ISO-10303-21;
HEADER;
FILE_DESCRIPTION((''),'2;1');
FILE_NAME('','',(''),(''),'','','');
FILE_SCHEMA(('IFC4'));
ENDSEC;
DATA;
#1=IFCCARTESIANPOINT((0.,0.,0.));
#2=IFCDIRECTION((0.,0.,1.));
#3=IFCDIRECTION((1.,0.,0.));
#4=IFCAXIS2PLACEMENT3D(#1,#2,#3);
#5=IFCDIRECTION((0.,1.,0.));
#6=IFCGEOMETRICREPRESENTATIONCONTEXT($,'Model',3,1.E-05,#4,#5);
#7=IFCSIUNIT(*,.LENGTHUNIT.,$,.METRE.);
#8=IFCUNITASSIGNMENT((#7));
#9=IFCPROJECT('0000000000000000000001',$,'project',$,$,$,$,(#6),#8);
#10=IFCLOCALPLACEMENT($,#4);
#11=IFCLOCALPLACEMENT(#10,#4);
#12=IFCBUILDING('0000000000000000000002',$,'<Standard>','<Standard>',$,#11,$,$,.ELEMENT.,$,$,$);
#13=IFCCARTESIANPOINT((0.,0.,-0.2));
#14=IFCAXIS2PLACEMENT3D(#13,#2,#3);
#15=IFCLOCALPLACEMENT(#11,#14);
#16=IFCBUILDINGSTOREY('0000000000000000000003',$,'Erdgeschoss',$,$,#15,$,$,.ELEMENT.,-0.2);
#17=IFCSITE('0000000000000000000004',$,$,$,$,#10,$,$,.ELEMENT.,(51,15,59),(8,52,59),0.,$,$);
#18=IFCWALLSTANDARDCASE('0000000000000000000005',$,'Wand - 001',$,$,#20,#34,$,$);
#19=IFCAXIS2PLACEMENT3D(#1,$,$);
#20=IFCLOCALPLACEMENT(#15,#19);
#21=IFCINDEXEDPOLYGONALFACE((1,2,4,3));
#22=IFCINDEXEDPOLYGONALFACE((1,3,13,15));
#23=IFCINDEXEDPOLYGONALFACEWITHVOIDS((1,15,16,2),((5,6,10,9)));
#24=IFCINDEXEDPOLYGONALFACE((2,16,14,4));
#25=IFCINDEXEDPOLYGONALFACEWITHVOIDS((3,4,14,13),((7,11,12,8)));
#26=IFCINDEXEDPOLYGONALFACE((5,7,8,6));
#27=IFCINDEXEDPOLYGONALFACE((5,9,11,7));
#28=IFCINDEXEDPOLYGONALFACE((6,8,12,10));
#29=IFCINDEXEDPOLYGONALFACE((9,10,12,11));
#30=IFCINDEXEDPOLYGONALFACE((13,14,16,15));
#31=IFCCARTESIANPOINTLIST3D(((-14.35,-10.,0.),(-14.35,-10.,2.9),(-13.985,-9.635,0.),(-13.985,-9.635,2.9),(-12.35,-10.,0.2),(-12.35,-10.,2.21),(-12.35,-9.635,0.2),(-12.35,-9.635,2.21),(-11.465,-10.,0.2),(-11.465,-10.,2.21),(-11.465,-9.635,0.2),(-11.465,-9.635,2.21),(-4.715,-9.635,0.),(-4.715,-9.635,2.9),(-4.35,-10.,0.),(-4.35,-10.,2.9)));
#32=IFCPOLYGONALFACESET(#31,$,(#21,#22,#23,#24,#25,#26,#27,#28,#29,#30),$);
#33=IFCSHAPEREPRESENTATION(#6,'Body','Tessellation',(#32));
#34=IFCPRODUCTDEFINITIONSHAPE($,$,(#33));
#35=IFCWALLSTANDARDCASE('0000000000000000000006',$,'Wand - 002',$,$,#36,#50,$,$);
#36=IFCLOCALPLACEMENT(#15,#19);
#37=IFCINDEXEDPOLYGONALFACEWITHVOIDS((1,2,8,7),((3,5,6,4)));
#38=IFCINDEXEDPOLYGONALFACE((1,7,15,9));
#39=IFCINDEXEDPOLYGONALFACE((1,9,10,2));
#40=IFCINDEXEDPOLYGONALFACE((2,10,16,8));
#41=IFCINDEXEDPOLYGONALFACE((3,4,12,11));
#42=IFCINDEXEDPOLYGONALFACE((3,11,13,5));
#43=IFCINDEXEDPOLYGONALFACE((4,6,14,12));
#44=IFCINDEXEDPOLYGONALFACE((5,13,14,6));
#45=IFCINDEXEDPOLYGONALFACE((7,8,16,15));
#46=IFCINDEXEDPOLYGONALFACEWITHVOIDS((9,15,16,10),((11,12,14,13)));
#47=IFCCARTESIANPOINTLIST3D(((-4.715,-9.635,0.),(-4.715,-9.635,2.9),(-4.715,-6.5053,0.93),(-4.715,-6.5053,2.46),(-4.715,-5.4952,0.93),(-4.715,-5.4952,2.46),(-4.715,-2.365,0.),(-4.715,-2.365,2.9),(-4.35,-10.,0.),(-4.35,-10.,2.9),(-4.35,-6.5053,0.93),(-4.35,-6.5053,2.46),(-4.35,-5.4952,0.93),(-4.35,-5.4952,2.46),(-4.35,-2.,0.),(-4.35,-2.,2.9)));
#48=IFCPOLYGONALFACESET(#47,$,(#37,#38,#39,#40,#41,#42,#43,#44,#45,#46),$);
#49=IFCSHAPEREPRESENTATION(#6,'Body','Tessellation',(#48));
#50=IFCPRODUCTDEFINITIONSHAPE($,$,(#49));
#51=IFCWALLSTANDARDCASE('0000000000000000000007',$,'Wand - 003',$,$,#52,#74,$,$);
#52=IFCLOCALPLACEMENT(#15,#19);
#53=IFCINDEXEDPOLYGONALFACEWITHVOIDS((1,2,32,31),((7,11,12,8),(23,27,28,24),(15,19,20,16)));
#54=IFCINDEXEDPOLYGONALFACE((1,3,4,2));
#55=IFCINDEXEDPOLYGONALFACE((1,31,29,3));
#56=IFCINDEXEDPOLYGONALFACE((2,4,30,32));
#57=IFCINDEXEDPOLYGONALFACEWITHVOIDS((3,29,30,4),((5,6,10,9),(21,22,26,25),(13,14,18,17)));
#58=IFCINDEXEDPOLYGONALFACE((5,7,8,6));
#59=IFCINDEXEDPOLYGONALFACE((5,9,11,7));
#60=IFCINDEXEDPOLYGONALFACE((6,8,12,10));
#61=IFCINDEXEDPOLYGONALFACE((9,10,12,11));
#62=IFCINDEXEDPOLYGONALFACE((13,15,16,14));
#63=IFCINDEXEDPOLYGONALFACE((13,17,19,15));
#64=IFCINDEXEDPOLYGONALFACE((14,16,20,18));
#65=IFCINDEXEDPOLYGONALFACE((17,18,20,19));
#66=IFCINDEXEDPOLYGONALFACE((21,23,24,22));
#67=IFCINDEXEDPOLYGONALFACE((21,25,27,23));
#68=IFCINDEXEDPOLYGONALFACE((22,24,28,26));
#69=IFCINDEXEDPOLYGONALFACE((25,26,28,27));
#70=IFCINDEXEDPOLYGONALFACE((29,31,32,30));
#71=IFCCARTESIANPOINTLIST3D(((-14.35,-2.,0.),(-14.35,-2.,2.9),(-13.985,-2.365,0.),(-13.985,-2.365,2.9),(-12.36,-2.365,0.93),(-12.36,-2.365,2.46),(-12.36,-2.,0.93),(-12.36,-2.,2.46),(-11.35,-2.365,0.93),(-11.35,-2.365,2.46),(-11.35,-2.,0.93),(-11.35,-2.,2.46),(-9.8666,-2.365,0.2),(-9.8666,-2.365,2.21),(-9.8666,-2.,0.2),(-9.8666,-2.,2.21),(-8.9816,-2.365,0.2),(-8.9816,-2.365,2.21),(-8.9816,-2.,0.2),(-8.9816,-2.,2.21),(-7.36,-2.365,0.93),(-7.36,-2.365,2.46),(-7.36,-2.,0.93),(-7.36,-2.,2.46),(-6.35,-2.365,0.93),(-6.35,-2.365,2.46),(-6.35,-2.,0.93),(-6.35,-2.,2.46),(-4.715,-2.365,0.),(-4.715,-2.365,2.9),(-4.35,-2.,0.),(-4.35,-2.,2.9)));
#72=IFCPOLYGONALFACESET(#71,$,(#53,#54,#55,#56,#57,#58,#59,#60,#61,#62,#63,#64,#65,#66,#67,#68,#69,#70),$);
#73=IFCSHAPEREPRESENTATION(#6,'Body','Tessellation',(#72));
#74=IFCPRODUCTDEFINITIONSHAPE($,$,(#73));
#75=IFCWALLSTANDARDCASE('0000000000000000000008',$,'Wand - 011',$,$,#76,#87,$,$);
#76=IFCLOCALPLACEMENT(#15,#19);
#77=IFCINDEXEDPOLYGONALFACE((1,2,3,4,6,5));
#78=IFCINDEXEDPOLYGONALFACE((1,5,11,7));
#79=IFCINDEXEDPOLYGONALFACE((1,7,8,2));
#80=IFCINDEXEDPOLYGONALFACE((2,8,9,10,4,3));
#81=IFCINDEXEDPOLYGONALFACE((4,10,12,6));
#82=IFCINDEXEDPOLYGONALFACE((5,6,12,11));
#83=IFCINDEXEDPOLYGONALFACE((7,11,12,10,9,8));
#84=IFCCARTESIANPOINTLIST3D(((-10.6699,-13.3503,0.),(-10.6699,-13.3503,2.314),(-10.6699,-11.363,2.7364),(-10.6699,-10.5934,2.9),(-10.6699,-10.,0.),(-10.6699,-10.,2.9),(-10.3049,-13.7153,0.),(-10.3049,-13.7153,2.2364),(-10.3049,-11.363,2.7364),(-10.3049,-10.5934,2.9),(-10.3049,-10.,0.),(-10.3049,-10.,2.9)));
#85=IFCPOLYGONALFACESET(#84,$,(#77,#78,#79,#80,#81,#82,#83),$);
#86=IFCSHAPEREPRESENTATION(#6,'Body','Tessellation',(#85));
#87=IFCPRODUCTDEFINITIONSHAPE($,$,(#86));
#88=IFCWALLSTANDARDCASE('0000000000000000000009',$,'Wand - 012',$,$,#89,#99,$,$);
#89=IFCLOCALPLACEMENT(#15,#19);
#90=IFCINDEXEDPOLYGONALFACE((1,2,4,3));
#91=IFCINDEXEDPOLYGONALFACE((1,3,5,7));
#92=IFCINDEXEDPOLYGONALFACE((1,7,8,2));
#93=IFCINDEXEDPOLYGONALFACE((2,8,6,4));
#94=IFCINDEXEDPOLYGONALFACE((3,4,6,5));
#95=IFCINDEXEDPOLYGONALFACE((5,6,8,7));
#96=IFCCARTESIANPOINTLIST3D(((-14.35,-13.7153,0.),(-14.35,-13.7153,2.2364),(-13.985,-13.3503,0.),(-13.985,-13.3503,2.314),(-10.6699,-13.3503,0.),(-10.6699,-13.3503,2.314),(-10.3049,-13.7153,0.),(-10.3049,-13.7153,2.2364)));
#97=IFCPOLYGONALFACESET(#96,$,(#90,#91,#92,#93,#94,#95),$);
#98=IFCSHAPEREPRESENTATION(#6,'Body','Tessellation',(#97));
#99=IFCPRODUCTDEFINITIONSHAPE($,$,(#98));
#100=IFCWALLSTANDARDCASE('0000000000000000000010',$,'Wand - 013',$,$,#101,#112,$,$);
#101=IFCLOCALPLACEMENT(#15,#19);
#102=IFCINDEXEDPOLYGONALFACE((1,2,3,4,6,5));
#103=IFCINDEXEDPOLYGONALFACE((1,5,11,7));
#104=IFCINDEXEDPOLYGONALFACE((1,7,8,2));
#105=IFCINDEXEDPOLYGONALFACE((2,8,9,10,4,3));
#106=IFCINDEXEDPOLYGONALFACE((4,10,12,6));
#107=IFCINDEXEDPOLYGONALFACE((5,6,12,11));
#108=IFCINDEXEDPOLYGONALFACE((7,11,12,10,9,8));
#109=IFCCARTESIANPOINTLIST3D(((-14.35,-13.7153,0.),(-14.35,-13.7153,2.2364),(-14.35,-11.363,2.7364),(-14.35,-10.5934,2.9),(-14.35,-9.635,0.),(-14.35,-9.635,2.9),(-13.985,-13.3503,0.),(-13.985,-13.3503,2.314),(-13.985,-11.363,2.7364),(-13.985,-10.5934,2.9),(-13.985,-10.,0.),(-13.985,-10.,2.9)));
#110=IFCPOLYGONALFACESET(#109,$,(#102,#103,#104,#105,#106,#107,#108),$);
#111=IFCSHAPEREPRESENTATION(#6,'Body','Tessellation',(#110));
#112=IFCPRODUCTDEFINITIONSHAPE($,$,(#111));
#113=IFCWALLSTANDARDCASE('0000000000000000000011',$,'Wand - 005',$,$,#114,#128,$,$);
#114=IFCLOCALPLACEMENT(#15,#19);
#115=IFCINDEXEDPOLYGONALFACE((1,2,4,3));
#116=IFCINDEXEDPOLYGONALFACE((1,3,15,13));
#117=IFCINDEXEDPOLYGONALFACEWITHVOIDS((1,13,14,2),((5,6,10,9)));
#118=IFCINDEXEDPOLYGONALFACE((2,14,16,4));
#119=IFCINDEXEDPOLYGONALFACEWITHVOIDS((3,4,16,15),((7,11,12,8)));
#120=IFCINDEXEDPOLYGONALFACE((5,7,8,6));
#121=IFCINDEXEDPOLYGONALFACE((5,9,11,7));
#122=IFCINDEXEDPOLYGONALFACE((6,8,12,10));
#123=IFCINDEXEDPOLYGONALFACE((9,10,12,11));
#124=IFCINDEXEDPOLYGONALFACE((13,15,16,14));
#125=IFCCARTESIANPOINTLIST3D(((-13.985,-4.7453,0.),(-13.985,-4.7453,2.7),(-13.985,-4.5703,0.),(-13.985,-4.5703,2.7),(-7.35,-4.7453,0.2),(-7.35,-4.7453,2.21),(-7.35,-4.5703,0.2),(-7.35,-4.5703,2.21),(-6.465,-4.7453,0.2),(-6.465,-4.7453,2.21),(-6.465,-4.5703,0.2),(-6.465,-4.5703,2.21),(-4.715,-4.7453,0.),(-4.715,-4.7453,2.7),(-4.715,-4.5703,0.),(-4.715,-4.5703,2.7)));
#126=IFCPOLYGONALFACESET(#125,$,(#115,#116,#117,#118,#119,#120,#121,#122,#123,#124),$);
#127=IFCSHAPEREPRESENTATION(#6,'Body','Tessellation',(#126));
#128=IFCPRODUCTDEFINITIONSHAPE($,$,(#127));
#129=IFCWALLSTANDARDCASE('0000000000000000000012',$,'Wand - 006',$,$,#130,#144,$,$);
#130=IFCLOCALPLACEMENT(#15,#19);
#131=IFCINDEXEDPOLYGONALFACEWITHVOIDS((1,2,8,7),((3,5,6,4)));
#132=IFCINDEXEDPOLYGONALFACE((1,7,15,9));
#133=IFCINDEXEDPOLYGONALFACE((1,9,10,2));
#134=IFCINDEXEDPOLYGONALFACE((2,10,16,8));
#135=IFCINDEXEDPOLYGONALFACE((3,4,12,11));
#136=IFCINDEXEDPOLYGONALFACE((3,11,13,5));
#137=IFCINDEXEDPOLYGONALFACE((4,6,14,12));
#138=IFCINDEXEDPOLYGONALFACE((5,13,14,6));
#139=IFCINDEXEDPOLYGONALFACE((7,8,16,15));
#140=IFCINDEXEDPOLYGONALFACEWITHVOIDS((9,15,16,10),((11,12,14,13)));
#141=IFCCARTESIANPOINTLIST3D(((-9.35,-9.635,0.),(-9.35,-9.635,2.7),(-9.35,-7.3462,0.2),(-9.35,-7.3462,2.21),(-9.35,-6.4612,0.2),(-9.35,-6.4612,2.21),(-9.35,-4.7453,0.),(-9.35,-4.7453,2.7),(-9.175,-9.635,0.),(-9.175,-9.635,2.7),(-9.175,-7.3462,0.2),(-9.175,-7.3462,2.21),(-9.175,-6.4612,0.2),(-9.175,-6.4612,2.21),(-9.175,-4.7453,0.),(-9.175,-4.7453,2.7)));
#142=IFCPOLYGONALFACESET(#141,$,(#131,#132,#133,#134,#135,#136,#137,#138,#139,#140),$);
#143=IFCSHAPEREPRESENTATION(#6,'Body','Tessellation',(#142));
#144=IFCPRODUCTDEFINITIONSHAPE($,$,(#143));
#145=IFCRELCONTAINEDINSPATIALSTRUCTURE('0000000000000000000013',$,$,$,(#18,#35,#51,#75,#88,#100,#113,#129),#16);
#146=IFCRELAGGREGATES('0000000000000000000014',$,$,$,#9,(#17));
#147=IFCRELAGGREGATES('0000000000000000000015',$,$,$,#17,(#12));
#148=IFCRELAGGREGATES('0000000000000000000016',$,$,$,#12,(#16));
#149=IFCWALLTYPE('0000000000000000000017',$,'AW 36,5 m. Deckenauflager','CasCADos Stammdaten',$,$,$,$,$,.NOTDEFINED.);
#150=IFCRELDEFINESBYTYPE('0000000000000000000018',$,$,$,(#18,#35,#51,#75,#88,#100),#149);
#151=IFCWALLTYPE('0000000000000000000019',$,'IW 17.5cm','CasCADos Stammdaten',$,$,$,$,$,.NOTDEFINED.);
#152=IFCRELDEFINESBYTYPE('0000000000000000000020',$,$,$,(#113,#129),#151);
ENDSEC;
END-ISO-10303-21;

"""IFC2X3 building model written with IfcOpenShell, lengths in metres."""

from ifc_helpers import new_model, si_unit, direction, frame, origin_with_axes, place, context, project, spatial, polyline, outline, extrude, clip, bounded_halfspace, type_object, element, save


model = new_model("IFC2X3")

# Units and contexts
model_context = context("Model", 3, precision=1e-05, world=origin_with_axes(), true_north=direction((0.0, 1.0, 0.0)))
ifc_project = project(units=[si_unit("LENGTHUNIT", "METRE")], contexts=[model_context])

# Site, building, storey
site_placement = place(None, origin_with_axes())
site = spatial("IfcSite", under=ifc_project, at=site_placement, CompositionType="ELEMENT", RefLatitude=(51, 15, 59), RefLongitude=(8, 52, 59), RefElevation=0.0)
building_placement = place(site_placement, origin_with_axes())
building = spatial("IfcBuilding", under=site, at=building_placement, Name="<Standard>", Description="<Standard>", CompositionType="ELEMENT")
storey_placement = place(building_placement, frame((0.0, 0.0, -0.2), z_axis=(0.0, 0.0, 1.0), x_axis=(1.0, 0.0, 0.0)))
storey = spatial("IfcBuildingStorey", under=building, at=storey_placement, Name="Erdgeschoss", CompositionType="ELEMENT", Elevation=-0.2)

# Walls, openings
wall_type_1 = type_object("IfcWallType", Name="AW 36,5 m. Deckenauflager", Description="CasCADos Stammdaten", PredefinedType="NOTDEFINED")
wall_1_placement = place(storey_placement, frame((-14.35, -10.0, 0.0), z_axis=(0.0, 0.0, 1.0), x_axis=(1.0, 0.0, 0.0)))
wall_1 = element("IfcWallStandardCase", 1, at=wall_1_placement, inside=storey, type_object=wall_type_1, Name="Wand - 001", context=model_context, shape_type="SweptSolid", body=[
    extrude(outline(polyline([(0.365, 0.365), (0.0, 0.0), (10.0, 0.0), (9.635, 0.365), (0.365, 0.365)])), origin_with_axes(), (0.0, 0.0, 1.0), 2.9),
])
opening_1_placement = place(wall_1_placement, frame((2.4425, 0.1825, 0.2), z_axis=(0.0, 0.0, 1.0), x_axis=(1.0, 0.0, 0.0)))
element("IfcOpeningElement", 2, at=opening_1_placement, cuts=wall_1, context=model_context, shape_type="SweptSolid", body=[
    extrude(outline(polyline([(0.0, 0.4425), (0.0, -0.4425), (2.01, -0.4425), (2.01, 0.4425), (0.0, 0.4425)])), frame((0.0, -0.1825, 0.0), z_axis=(0.0, 1.0, 0.0), x_axis=(0.0, 0.0, 1.0)), (0.0, 0.0, 1.0), 0.365),
])
wall_2_placement = place(storey_placement, frame((-4.35, -10.0, 0.0), z_axis=(0.0, 0.0, 1.0), x_axis=(0.0, 1.0, 0.0)))
wall_2 = element("IfcWallStandardCase", 3, at=wall_2_placement, inside=storey, type_object=wall_type_1, Name="Wand - 002", context=model_context, shape_type="SweptSolid", body=[
    extrude(outline(polyline([(0.365, 0.365), (0.0, 0.0), (8.0, 0.0), (7.635, 0.365), (0.365, 0.365)])), origin_with_axes(), (0.0, 0.0, 1.0), 2.9),
])
opening_2_placement = place(wall_2_placement, frame((3.9998, 0.1825, 0.2), z_axis=(0.0, 0.0, 1.0), x_axis=(1.0, 0.0, 0.0)))
element("IfcOpeningElement", 4, at=opening_2_placement, cuts=wall_2, context=model_context, shape_type="SweptSolid", body=[
    extrude(outline(polyline([(0.73, 0.505), (0.73, -0.505), (2.26, -0.505), (2.26, 0.505), (0.73, 0.505)])), frame((0.0, -0.1825, 0.0), z_axis=(0.0, 1.0, 0.0), x_axis=(0.0, 0.0, 1.0)), (0.0, 0.0, 1.0), 0.365),
])

# Wall, openings
wall_3_placement = place(storey_placement, frame((-4.35, -2.0, 0.0), z_axis=(0.0, 0.0, 1.0), x_axis=(-1.0, 0.0, 0.0)))
wall_3 = element("IfcWallStandardCase", 5, at=wall_3_placement, inside=storey, type_object=wall_type_1, Name="Wand - 003", context=model_context, shape_type="SweptSolid", body=[
    extrude(outline(polyline([(0.365, 0.365), (0.0, 0.0), (10.0, 0.0), (9.635, 0.365), (0.365, 0.365)])), origin_with_axes(), (0.0, 0.0, 1.0), 2.9),
])
opening_3_placement = place(wall_3_placement, frame((5.0741, 0.1825, 0.2), z_axis=(0.0, 0.0, 1.0), x_axis=(1.0, 0.0, 0.0)))
element("IfcOpeningElement", 6, at=opening_3_placement, cuts=wall_3, context=model_context, shape_type="SweptSolid", body=[
    extrude(outline(polyline([(0.0, 0.4425), (0.0, -0.4425), (2.01, -0.4425), (2.01, 0.4425), (0.0, 0.4425)])), frame((0.0, -0.1825, 0.0), z_axis=(0.0, 1.0, 0.0), x_axis=(0.0, 0.0, 1.0)), (0.0, 0.0, 1.0), 0.365),
])
opening_4_placement = place(wall_3_placement, frame((7.505, 0.1825, 0.2), z_axis=(0.0, 0.0, 1.0), x_axis=(1.0, 0.0, 0.0)))
element("IfcOpeningElement", 7, at=opening_4_placement, cuts=wall_3, context=model_context, shape_type="SweptSolid", body=[
    extrude(outline(polyline([(0.73, 0.505), (0.73, -0.505), (2.26, -0.505), (2.26, 0.505), (0.73, 0.505)])), frame((0.0, -0.1825, 0.0), z_axis=(0.0, 1.0, 0.0), x_axis=(0.0, 0.0, 1.0)), (0.0, 0.0, 1.0), 0.365),
])
opening_5_placement = place(wall_3_placement, frame((2.505, 0.1825, 0.2), z_axis=(0.0, 0.0, 1.0), x_axis=(1.0, 0.0, 0.0)))
element("IfcOpeningElement", 8, at=opening_5_placement, cuts=wall_3, context=model_context, shape_type="SweptSolid", body=[
    extrude(outline(polyline([(0.73, 0.505), (0.73, -0.505), (2.26, -0.505), (2.26, 0.505), (0.73, 0.505)])), frame((0.0, -0.1825, 0.0), z_axis=(0.0, 1.0, 0.0), x_axis=(0.0, 0.0, 1.0)), (0.0, 0.0, 1.0), 0.365),
])

# Walls
wall_4_placement = place(storey_placement, frame((-10.6699, -10.0, 0.0), z_axis=(0.0, 0.0, 1.0), x_axis=(0.0, -1.0, 0.0)))
element("IfcWallStandardCase", 9, at=wall_4_placement, inside=storey, type_object=wall_type_1, Name="Wand - 011", context=model_context, shape_type="Clipping", body=[
    clip(clip(extrude(outline(polyline([(0.0, 0.365), (0.0, 0.0), (3.3503, 0.0), (3.7153, 0.365), (0.0, 0.365)])), origin_with_axes(), (0.0, 0.0, 1.0), 2.9), bounded_halfspace(frame((-8.993, 10.6699, 4.9376), z_axis=(0.207912, 0.0, 0.978148), x_axis=(0.0, 1.0, 0.0)), False, origin_with_axes(), polyline([(1.363, 0.365), (1.363, 0.0), (3.3503, 0.0), (3.7153, 0.365), (1.363, 0.365)]))), bounded_halfspace(frame((-8.993, 10.6699, 4.9376), z_axis=(0.207912, 0.0, 0.978148), x_axis=(0.0, 1.0, 0.0)), False, origin_with_axes(), polyline([(1.363, 0.0), (1.363, 0.365), (0.5934, 0.365), (0.5934, 0.0), (1.363, 0.0)]))),
])
wall_5_placement = place(storey_placement, frame((-10.6699, -13.3503, 0.0), z_axis=(0.0, 0.0, 1.0), x_axis=(-1.0, 0.0, 0.0)))
element("IfcWallStandardCase", 10, at=wall_5_placement, inside=storey, type_object=wall_type_1, Name="Wand - 012", context=model_context, shape_type="Clipping", body=[
    clip(extrude(outline(polyline([(-0.365, 0.365), (0.0, 0.0), (3.3151, 0.0), (3.6801, 0.365), (-0.365, 0.365)])), origin_with_axes(), (0.0, 0.0, 1.0), 2.9), bounded_halfspace(frame((-10.6699, -12.3433, 4.9376), z_axis=(0.0, 0.207912, 0.978148), x_axis=(-1.0, 0.0, 0.0)), False, origin_with_axes(), polyline([(3.3151, 0.0), (3.6801, 0.365), (-0.365, 0.365), (0.0, 0.0), (3.3151, 0.0)]))),
])
wall_6_placement = place(storey_placement, frame((-13.985, -13.3503, 0.0), z_axis=(0.0, 0.0, 1.0), x_axis=(0.0, 1.0, 0.0)))
element("IfcWallStandardCase", 11, at=wall_6_placement, inside=storey, type_object=wall_type_1, Name="Wand - 013", context=model_context, shape_type="Clipping", body=[
    clip(clip(extrude(outline(polyline([(-0.365, 0.365), (0.0, 0.0), (3.3503, 0.0), (3.7153, 0.365), (-0.365, 0.365)])), origin_with_axes(), (0.0, 0.0, 1.0), 2.9), bounded_halfspace(frame((12.3433, -13.985, 4.9376), z_axis=(-0.207912, 0.0, 0.978148), x_axis=(0.0, -1.0, 0.0)), False, origin_with_axes(), polyline([(1.9873, 0.0), (1.9873, 0.365), (-0.365, 0.365), (0.0, 0.0), (1.9873, 0.0)]))), bounded_halfspace(frame((12.3433, -13.985, 4.9376), z_axis=(-0.207912, 0.0, 0.978148), x_axis=(0.0, -1.0, 0.0)), False, origin_with_axes(), polyline([(1.9873, 0.365), (1.9873, 0.0), (2.7569, 0.0), (2.7569, 0.365), (1.9873, 0.365)]))),
])

# Walls, openings
wall_type_2 = type_object("IfcWallType", Name="IW 17.5cm", Description="CasCADos Stammdaten", PredefinedType="NOTDEFINED")
wall_7_placement = place(storey_placement, frame((-13.985, -4.7453, 0.0), z_axis=(0.0, 0.0, 1.0), x_axis=(1.0, 0.0, 0.0)))
wall_7 = element("IfcWallStandardCase", 12, at=wall_7_placement, inside=storey, type_object=wall_type_2, Name="Wand - 005", context=model_context, shape_type="SweptSolid", body=[
    extrude(outline(polyline([(0.0, 0.175), (0.0, 0.0), (9.27, 0.0), (9.27, 0.175), (0.0, 0.175)])), origin_with_axes(), (0.0, 0.0, 1.0), 2.7),
])
opening_6_placement = place(wall_7_placement, frame((7.0775, 0.0875, 0.2), z_axis=(0.0, 0.0, 1.0), x_axis=(1.0, 0.0, 0.0)))
element("IfcOpeningElement", 13, at=opening_6_placement, cuts=wall_7, context=model_context, shape_type="SweptSolid", body=[
    extrude(outline(polyline([(0.0, 0.4425), (0.0, -0.4425), (2.01, -0.4425), (2.01, 0.4425), (0.0, 0.4425)])), frame((0.0, -0.0875, 0.0), z_axis=(0.0, 1.0, 0.0), x_axis=(0.0, 0.0, 1.0)), (0.0, 0.0, 1.0), 0.175),
])
wall_8_placement = place(storey_placement, frame((-9.35, -4.7453, 0.0), z_axis=(0.0, 0.0, 1.0), x_axis=(0.0, -1.0, 0.0)))
wall_8 = element("IfcWallStandardCase", 14, at=wall_8_placement, inside=storey, type_object=wall_type_2, Name="Wand - 006", context=model_context, shape_type="SweptSolid", body=[
    extrude(outline(polyline([(0.0, 0.175), (0.0, 0.0), (4.8897, 0.0), (4.8897, 0.175), (0.0, 0.175)])), origin_with_axes(), (0.0, 0.0, 1.0), 2.7),
])
opening_7_placement = place(wall_8_placement, frame((2.1584, 0.0875, 0.2), z_axis=(0.0, 0.0, 1.0), x_axis=(1.0, 0.0, 0.0)))
element("IfcOpeningElement", 15, at=opening_7_placement, cuts=wall_8, context=model_context, shape_type="SweptSolid", body=[
    extrude(outline(polyline([(0.0, 0.4425), (0.0, -0.4425), (2.01, -0.4425), (2.01, 0.4425), (0.0, 0.4425)])), frame((0.0, -0.0875, 0.0), z_axis=(0.0, 1.0, 0.0), x_axis=(0.0, 0.0, 1.0)), (0.0, 0.0, 1.0), 0.175),
])

save(model, "model.ifc")
